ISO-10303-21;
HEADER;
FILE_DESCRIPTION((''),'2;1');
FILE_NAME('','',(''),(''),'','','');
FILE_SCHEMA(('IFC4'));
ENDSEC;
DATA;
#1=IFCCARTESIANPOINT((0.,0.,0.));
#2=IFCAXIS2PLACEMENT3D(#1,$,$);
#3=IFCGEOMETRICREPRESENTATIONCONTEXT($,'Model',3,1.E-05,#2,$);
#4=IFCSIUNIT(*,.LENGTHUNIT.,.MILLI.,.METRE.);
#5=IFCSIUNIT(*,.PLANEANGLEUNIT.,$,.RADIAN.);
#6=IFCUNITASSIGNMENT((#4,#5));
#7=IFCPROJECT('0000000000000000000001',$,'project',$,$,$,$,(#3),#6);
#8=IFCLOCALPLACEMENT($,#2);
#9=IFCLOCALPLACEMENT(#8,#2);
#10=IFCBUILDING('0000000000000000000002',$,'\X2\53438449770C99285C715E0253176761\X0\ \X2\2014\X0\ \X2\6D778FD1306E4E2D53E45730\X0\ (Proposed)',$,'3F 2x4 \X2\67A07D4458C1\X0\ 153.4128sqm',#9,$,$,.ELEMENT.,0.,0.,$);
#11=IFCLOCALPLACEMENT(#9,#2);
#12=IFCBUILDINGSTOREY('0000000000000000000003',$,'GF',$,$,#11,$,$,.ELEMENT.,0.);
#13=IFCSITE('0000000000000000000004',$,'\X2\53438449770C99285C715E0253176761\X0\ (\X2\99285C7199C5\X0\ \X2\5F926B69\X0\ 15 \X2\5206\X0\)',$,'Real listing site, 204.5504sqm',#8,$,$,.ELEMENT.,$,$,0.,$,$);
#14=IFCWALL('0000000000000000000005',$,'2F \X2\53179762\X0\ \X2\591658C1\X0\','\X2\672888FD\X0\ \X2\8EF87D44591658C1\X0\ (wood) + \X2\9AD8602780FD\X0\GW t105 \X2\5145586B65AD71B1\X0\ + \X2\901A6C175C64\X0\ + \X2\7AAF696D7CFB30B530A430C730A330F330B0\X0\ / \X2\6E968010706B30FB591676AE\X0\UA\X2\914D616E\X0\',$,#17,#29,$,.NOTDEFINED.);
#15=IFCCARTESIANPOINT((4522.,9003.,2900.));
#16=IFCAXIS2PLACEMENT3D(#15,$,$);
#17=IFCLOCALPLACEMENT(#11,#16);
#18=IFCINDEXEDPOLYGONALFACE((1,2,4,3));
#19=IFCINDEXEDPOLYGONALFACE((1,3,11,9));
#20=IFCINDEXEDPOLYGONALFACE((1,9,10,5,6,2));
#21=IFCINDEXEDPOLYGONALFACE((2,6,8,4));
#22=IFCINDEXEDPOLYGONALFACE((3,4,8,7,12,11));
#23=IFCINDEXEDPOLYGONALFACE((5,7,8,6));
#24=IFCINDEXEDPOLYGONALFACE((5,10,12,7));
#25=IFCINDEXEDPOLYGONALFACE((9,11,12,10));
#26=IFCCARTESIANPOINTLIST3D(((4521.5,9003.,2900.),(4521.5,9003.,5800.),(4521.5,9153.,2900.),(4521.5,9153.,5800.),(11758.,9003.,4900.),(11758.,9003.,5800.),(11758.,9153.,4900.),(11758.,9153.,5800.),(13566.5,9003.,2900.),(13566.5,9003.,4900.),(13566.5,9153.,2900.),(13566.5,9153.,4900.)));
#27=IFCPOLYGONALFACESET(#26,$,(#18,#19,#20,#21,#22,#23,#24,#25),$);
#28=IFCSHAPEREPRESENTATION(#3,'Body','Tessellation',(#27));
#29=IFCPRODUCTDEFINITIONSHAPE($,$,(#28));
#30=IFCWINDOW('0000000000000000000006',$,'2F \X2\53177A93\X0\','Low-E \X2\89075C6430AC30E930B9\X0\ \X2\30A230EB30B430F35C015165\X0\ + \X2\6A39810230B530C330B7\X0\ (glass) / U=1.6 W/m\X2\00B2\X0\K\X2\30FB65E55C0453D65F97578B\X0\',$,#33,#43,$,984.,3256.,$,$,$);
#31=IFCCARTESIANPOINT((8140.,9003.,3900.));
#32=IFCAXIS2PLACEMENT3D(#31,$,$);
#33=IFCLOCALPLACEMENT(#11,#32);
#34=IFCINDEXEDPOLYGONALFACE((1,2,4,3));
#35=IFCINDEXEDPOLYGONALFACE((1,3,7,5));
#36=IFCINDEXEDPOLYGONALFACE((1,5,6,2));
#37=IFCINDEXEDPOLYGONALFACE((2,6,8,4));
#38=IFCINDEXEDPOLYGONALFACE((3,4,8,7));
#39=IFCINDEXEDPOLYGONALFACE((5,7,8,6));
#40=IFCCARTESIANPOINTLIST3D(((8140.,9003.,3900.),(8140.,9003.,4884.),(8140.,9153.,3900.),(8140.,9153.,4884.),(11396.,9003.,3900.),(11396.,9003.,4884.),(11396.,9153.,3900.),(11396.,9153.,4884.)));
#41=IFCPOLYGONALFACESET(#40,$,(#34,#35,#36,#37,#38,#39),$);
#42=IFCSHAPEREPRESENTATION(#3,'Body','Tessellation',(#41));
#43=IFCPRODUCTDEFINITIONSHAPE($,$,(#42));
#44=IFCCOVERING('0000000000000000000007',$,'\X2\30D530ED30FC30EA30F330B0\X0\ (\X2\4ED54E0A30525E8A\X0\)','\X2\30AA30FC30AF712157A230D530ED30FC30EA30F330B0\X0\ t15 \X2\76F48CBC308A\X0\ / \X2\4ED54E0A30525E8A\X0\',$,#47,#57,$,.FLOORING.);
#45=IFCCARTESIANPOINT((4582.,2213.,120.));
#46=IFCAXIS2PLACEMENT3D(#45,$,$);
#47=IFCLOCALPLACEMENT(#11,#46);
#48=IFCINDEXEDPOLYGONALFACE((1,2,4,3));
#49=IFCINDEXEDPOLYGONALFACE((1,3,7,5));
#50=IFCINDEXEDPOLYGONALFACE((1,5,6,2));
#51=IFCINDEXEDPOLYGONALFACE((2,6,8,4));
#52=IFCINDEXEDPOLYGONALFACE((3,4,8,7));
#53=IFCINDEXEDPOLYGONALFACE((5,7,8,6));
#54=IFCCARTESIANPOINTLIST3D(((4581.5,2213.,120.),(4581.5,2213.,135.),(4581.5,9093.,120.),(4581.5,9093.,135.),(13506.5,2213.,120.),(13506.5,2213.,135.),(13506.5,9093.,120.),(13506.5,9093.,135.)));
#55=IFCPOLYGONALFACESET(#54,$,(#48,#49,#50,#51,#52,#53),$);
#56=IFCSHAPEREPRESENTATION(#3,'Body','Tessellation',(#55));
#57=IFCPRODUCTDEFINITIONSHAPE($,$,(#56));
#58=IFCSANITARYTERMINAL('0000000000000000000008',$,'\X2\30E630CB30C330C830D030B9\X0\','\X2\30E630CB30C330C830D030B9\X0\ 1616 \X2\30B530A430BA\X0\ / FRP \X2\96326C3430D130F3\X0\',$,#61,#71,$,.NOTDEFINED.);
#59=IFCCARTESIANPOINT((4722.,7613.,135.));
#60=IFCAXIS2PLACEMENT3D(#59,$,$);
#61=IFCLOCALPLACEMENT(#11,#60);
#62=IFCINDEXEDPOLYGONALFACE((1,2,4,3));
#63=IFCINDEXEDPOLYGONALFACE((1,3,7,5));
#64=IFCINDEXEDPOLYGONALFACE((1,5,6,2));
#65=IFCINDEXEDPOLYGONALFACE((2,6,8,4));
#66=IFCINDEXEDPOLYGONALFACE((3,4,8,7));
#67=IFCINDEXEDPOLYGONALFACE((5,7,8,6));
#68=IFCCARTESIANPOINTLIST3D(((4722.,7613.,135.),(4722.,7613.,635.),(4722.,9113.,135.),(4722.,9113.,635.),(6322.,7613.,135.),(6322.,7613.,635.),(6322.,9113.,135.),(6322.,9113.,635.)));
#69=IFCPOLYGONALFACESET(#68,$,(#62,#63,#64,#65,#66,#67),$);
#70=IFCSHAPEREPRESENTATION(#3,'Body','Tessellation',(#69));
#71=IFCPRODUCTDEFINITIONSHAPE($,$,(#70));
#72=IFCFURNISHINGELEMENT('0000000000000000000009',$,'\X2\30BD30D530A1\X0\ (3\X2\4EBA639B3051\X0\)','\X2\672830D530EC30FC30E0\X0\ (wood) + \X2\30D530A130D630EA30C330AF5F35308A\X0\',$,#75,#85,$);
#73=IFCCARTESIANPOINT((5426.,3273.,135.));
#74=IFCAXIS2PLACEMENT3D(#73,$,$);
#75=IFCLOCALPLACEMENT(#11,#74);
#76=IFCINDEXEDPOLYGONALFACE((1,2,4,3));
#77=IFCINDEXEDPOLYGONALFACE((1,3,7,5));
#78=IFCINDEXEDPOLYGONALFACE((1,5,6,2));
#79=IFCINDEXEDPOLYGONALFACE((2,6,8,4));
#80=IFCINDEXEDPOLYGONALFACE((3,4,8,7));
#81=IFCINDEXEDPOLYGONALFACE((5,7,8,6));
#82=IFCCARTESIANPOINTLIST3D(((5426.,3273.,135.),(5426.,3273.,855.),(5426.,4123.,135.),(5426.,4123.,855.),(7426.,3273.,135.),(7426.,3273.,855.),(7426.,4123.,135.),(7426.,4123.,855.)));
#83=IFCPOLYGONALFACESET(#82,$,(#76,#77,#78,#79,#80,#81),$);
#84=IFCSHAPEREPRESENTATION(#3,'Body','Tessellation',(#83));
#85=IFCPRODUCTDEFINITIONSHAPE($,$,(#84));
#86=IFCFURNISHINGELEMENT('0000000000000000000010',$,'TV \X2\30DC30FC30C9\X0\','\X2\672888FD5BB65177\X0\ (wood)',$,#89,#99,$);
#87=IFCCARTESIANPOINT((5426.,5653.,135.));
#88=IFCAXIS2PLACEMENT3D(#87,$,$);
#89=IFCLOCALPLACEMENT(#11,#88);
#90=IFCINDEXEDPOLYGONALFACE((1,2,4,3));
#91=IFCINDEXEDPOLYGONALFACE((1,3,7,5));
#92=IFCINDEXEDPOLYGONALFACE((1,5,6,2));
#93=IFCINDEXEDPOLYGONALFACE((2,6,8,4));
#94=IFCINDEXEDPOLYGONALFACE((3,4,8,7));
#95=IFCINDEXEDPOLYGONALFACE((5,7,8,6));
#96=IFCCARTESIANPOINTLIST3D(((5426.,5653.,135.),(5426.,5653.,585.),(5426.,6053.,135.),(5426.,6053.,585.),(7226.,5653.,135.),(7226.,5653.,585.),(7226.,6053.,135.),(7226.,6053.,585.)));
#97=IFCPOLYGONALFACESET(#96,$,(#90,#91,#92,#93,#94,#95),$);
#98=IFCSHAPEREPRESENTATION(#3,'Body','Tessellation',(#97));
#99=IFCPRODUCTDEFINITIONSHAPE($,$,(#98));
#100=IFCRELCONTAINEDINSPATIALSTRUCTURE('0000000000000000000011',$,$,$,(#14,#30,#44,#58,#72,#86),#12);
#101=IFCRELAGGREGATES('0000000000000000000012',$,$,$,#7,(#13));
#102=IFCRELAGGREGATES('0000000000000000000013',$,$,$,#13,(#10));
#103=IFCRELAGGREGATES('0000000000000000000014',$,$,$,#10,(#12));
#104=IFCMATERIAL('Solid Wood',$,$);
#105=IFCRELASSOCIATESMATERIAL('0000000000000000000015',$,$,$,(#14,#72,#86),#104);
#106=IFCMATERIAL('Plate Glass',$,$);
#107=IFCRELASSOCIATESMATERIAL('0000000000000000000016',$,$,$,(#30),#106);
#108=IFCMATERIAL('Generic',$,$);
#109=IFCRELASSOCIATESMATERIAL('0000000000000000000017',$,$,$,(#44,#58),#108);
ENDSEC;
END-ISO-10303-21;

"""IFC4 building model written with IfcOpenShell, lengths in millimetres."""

from ifc_helpers import new_model, si_unit, frame, frame_2d, origin, place, context, project, spatial, rectangle, extrude, material, element, fill, save


model = new_model("IFC4")

# Units and contexts
model_context = context("Model", 3, precision=1e-05, world=origin())
ifc_project = project(units=[si_unit("LENGTHUNIT", "METRE", prefix="MILLI"), si_unit("PLANEANGLEUNIT", "RADIAN")], contexts=[model_context])

# Site, building, storey
site_placement = place(None, origin())
site = spatial("IfcSite", under=ifc_project, at=site_placement, Name="千葉県館山市北条 (館山駅 徒歩 15 分)", ObjectType="Real listing site, 204.5504sqm", CompositionType="ELEMENT", RefElevation=0.0)
building_placement = place(site_placement, origin())
building = spatial("IfcBuilding", under=site, at=building_placement, Name="千葉県館山市北条 — 海近の中古地 (Proposed)", ObjectType="3F 2x4 枠組壁 153.4128sqm", CompositionType="ELEMENT", ElevationOfRefHeight=0.0, ElevationOfTerrain=0.0)
storey_placement = place(building_placement, origin())
storey = spatial("IfcBuildingStorey", under=building, at=storey_placement, Name="GF", CompositionType="ELEMENT", Elevation=0.0)

# Shared definitions
ifc_material_1 = material(Name="Solid Wood")

# Shared definitions
ifc_material_2 = material(Name="Plate Glass")

# Wall, opening, window
wall_1_placement = place(storey_placement, frame((4522.0, 9003.0, 2900.0)))
wall_1 = element("IfcWall", 1, at=wall_1_placement, inside=storey, material=ifc_material_1, Name="2F 北面 外壁", Description="木製 軸組外壁 (wood) + 高性能GW t105 充填断熱 + 通気層 + 窯業系サイディング / 準耐火・外皮UA配慮", PredefinedType="NOTDEFINED", context=model_context, shape_type="SweptSolid", body=[
    extrude(rectangle(XDim=9045.0, YDim=150.0, at=frame_2d((4522.0, 75.0))), frame((4522.0, 9003.0, 2900.0)), (0.0, 0.0, 1.0), 2900.0),
])
opening_1_placement = place(storey_placement, frame((8140.0, 9003.0, 3900.0)))
opening_1 = element("IfcOpeningElement", 2, at=opening_1_placement, cuts=wall_1, PredefinedType="NOTDEFINED", context=model_context, shape_type="SweptSolid", body=[
    extrude(rectangle(XDim=3256.0, YDim=150.0, at=frame_2d((1628.0, 75.0))), frame((8140.0, 9003.0, 3900.0)), (0.0, 0.0, 1.0), 984.0),
])
window_1_placement = place(storey_placement, frame((8140.0, 9003.0, 3900.0)))
window_1 = element("IfcWindow", 3, at=window_1_placement, inside=storey, material=ifc_material_2, Name="2F 北窓", Description="Low-E 複層ガラス アルゴン封入 + 樹脂サッシ (glass) / U=1.6 W/m²K・日射取得型", OverallHeight=984.0, OverallWidth=3256.0, context=model_context, shape_type="SweptSolid", body=[
    extrude(rectangle(XDim=3256.0, YDim=150.0, at=frame_2d((1628.0, 75.0))), frame((8140.0, 9003.0, 3900.0)), (0.0, 0.0, 1.0), 984.0),
])
fill(opening_1, window_1)

# Covering
ifc_material_3 = material(Name="Generic")
covering_placement = place(storey_placement, frame((4582.0, 2213.0, 120.0)))
element("IfcCovering", 4, at=covering_placement, inside=storey, material=ifc_material_3, Name="フローリング (仕上げ床)", Description="オーク無垢フローリング t15 直貼り / 仕上げ床", PredefinedType="FLOORING", context=model_context, shape_type="SweptSolid", body=[
    extrude(rectangle(XDim=8925.0, YDim=6880.0, at=frame_2d((4462.0, 3440.0))), frame((4582.0, 2213.0, 120.0)), (0.0, 0.0, 1.0), 15.0),
])

# Sanitary terminal
sanitary_terminal_placement = place(storey_placement, frame((4722.0, 7613.0, 135.0)))
element("IfcSanitaryTerminal", 5, at=sanitary_terminal_placement, inside=storey, material=ifc_material_3, Name="ユニットバス", Description="ユニットバス 1616 サイズ / FRP 防水パン", PredefinedType="NOTDEFINED", context=model_context, shape_type="SweptSolid", body=[
    extrude(rectangle(XDim=1600.0, YDim=1500.0, at=frame_2d((800.0, 750.0))), frame((4722.0, 7613.0, 135.0)), (0.0, 0.0, 1.0), 500.0),
])

# Furnishing elements
furnishing_1_placement = place(storey_placement, frame((5426.0, 3273.0, 135.0)))
element("IfcFurnishingElement", 6, at=furnishing_1_placement, inside=storey, material=ifc_material_1, Name="ソファ (3人掛け)", Description="木フレーム (wood) + ファブリック張り", context=model_context, shape_type="SweptSolid", body=[
    extrude(rectangle(XDim=2000.0, YDim=850.0, at=frame_2d((1000.0, 425.0))), frame((5426.0, 3273.0, 135.0)), (0.0, 0.0, 1.0), 720.0),
])
furnishing_2_placement = place(storey_placement, frame((5426.0, 5653.0, 135.0)))
element("IfcFurnishingElement", 7, at=furnishing_2_placement, inside=storey, material=ifc_material_1, Name="TV ボード", Description="木製家具 (wood)", context=model_context, shape_type="SweptSolid", body=[
    extrude(rectangle(XDim=1800.0, YDim=400.0, at=frame_2d((900.0, 200.0))), frame((5426.0, 5653.0, 135.0)), (0.0, 0.0, 1.0), 450.0),
])

save(model, "model.ifc")
